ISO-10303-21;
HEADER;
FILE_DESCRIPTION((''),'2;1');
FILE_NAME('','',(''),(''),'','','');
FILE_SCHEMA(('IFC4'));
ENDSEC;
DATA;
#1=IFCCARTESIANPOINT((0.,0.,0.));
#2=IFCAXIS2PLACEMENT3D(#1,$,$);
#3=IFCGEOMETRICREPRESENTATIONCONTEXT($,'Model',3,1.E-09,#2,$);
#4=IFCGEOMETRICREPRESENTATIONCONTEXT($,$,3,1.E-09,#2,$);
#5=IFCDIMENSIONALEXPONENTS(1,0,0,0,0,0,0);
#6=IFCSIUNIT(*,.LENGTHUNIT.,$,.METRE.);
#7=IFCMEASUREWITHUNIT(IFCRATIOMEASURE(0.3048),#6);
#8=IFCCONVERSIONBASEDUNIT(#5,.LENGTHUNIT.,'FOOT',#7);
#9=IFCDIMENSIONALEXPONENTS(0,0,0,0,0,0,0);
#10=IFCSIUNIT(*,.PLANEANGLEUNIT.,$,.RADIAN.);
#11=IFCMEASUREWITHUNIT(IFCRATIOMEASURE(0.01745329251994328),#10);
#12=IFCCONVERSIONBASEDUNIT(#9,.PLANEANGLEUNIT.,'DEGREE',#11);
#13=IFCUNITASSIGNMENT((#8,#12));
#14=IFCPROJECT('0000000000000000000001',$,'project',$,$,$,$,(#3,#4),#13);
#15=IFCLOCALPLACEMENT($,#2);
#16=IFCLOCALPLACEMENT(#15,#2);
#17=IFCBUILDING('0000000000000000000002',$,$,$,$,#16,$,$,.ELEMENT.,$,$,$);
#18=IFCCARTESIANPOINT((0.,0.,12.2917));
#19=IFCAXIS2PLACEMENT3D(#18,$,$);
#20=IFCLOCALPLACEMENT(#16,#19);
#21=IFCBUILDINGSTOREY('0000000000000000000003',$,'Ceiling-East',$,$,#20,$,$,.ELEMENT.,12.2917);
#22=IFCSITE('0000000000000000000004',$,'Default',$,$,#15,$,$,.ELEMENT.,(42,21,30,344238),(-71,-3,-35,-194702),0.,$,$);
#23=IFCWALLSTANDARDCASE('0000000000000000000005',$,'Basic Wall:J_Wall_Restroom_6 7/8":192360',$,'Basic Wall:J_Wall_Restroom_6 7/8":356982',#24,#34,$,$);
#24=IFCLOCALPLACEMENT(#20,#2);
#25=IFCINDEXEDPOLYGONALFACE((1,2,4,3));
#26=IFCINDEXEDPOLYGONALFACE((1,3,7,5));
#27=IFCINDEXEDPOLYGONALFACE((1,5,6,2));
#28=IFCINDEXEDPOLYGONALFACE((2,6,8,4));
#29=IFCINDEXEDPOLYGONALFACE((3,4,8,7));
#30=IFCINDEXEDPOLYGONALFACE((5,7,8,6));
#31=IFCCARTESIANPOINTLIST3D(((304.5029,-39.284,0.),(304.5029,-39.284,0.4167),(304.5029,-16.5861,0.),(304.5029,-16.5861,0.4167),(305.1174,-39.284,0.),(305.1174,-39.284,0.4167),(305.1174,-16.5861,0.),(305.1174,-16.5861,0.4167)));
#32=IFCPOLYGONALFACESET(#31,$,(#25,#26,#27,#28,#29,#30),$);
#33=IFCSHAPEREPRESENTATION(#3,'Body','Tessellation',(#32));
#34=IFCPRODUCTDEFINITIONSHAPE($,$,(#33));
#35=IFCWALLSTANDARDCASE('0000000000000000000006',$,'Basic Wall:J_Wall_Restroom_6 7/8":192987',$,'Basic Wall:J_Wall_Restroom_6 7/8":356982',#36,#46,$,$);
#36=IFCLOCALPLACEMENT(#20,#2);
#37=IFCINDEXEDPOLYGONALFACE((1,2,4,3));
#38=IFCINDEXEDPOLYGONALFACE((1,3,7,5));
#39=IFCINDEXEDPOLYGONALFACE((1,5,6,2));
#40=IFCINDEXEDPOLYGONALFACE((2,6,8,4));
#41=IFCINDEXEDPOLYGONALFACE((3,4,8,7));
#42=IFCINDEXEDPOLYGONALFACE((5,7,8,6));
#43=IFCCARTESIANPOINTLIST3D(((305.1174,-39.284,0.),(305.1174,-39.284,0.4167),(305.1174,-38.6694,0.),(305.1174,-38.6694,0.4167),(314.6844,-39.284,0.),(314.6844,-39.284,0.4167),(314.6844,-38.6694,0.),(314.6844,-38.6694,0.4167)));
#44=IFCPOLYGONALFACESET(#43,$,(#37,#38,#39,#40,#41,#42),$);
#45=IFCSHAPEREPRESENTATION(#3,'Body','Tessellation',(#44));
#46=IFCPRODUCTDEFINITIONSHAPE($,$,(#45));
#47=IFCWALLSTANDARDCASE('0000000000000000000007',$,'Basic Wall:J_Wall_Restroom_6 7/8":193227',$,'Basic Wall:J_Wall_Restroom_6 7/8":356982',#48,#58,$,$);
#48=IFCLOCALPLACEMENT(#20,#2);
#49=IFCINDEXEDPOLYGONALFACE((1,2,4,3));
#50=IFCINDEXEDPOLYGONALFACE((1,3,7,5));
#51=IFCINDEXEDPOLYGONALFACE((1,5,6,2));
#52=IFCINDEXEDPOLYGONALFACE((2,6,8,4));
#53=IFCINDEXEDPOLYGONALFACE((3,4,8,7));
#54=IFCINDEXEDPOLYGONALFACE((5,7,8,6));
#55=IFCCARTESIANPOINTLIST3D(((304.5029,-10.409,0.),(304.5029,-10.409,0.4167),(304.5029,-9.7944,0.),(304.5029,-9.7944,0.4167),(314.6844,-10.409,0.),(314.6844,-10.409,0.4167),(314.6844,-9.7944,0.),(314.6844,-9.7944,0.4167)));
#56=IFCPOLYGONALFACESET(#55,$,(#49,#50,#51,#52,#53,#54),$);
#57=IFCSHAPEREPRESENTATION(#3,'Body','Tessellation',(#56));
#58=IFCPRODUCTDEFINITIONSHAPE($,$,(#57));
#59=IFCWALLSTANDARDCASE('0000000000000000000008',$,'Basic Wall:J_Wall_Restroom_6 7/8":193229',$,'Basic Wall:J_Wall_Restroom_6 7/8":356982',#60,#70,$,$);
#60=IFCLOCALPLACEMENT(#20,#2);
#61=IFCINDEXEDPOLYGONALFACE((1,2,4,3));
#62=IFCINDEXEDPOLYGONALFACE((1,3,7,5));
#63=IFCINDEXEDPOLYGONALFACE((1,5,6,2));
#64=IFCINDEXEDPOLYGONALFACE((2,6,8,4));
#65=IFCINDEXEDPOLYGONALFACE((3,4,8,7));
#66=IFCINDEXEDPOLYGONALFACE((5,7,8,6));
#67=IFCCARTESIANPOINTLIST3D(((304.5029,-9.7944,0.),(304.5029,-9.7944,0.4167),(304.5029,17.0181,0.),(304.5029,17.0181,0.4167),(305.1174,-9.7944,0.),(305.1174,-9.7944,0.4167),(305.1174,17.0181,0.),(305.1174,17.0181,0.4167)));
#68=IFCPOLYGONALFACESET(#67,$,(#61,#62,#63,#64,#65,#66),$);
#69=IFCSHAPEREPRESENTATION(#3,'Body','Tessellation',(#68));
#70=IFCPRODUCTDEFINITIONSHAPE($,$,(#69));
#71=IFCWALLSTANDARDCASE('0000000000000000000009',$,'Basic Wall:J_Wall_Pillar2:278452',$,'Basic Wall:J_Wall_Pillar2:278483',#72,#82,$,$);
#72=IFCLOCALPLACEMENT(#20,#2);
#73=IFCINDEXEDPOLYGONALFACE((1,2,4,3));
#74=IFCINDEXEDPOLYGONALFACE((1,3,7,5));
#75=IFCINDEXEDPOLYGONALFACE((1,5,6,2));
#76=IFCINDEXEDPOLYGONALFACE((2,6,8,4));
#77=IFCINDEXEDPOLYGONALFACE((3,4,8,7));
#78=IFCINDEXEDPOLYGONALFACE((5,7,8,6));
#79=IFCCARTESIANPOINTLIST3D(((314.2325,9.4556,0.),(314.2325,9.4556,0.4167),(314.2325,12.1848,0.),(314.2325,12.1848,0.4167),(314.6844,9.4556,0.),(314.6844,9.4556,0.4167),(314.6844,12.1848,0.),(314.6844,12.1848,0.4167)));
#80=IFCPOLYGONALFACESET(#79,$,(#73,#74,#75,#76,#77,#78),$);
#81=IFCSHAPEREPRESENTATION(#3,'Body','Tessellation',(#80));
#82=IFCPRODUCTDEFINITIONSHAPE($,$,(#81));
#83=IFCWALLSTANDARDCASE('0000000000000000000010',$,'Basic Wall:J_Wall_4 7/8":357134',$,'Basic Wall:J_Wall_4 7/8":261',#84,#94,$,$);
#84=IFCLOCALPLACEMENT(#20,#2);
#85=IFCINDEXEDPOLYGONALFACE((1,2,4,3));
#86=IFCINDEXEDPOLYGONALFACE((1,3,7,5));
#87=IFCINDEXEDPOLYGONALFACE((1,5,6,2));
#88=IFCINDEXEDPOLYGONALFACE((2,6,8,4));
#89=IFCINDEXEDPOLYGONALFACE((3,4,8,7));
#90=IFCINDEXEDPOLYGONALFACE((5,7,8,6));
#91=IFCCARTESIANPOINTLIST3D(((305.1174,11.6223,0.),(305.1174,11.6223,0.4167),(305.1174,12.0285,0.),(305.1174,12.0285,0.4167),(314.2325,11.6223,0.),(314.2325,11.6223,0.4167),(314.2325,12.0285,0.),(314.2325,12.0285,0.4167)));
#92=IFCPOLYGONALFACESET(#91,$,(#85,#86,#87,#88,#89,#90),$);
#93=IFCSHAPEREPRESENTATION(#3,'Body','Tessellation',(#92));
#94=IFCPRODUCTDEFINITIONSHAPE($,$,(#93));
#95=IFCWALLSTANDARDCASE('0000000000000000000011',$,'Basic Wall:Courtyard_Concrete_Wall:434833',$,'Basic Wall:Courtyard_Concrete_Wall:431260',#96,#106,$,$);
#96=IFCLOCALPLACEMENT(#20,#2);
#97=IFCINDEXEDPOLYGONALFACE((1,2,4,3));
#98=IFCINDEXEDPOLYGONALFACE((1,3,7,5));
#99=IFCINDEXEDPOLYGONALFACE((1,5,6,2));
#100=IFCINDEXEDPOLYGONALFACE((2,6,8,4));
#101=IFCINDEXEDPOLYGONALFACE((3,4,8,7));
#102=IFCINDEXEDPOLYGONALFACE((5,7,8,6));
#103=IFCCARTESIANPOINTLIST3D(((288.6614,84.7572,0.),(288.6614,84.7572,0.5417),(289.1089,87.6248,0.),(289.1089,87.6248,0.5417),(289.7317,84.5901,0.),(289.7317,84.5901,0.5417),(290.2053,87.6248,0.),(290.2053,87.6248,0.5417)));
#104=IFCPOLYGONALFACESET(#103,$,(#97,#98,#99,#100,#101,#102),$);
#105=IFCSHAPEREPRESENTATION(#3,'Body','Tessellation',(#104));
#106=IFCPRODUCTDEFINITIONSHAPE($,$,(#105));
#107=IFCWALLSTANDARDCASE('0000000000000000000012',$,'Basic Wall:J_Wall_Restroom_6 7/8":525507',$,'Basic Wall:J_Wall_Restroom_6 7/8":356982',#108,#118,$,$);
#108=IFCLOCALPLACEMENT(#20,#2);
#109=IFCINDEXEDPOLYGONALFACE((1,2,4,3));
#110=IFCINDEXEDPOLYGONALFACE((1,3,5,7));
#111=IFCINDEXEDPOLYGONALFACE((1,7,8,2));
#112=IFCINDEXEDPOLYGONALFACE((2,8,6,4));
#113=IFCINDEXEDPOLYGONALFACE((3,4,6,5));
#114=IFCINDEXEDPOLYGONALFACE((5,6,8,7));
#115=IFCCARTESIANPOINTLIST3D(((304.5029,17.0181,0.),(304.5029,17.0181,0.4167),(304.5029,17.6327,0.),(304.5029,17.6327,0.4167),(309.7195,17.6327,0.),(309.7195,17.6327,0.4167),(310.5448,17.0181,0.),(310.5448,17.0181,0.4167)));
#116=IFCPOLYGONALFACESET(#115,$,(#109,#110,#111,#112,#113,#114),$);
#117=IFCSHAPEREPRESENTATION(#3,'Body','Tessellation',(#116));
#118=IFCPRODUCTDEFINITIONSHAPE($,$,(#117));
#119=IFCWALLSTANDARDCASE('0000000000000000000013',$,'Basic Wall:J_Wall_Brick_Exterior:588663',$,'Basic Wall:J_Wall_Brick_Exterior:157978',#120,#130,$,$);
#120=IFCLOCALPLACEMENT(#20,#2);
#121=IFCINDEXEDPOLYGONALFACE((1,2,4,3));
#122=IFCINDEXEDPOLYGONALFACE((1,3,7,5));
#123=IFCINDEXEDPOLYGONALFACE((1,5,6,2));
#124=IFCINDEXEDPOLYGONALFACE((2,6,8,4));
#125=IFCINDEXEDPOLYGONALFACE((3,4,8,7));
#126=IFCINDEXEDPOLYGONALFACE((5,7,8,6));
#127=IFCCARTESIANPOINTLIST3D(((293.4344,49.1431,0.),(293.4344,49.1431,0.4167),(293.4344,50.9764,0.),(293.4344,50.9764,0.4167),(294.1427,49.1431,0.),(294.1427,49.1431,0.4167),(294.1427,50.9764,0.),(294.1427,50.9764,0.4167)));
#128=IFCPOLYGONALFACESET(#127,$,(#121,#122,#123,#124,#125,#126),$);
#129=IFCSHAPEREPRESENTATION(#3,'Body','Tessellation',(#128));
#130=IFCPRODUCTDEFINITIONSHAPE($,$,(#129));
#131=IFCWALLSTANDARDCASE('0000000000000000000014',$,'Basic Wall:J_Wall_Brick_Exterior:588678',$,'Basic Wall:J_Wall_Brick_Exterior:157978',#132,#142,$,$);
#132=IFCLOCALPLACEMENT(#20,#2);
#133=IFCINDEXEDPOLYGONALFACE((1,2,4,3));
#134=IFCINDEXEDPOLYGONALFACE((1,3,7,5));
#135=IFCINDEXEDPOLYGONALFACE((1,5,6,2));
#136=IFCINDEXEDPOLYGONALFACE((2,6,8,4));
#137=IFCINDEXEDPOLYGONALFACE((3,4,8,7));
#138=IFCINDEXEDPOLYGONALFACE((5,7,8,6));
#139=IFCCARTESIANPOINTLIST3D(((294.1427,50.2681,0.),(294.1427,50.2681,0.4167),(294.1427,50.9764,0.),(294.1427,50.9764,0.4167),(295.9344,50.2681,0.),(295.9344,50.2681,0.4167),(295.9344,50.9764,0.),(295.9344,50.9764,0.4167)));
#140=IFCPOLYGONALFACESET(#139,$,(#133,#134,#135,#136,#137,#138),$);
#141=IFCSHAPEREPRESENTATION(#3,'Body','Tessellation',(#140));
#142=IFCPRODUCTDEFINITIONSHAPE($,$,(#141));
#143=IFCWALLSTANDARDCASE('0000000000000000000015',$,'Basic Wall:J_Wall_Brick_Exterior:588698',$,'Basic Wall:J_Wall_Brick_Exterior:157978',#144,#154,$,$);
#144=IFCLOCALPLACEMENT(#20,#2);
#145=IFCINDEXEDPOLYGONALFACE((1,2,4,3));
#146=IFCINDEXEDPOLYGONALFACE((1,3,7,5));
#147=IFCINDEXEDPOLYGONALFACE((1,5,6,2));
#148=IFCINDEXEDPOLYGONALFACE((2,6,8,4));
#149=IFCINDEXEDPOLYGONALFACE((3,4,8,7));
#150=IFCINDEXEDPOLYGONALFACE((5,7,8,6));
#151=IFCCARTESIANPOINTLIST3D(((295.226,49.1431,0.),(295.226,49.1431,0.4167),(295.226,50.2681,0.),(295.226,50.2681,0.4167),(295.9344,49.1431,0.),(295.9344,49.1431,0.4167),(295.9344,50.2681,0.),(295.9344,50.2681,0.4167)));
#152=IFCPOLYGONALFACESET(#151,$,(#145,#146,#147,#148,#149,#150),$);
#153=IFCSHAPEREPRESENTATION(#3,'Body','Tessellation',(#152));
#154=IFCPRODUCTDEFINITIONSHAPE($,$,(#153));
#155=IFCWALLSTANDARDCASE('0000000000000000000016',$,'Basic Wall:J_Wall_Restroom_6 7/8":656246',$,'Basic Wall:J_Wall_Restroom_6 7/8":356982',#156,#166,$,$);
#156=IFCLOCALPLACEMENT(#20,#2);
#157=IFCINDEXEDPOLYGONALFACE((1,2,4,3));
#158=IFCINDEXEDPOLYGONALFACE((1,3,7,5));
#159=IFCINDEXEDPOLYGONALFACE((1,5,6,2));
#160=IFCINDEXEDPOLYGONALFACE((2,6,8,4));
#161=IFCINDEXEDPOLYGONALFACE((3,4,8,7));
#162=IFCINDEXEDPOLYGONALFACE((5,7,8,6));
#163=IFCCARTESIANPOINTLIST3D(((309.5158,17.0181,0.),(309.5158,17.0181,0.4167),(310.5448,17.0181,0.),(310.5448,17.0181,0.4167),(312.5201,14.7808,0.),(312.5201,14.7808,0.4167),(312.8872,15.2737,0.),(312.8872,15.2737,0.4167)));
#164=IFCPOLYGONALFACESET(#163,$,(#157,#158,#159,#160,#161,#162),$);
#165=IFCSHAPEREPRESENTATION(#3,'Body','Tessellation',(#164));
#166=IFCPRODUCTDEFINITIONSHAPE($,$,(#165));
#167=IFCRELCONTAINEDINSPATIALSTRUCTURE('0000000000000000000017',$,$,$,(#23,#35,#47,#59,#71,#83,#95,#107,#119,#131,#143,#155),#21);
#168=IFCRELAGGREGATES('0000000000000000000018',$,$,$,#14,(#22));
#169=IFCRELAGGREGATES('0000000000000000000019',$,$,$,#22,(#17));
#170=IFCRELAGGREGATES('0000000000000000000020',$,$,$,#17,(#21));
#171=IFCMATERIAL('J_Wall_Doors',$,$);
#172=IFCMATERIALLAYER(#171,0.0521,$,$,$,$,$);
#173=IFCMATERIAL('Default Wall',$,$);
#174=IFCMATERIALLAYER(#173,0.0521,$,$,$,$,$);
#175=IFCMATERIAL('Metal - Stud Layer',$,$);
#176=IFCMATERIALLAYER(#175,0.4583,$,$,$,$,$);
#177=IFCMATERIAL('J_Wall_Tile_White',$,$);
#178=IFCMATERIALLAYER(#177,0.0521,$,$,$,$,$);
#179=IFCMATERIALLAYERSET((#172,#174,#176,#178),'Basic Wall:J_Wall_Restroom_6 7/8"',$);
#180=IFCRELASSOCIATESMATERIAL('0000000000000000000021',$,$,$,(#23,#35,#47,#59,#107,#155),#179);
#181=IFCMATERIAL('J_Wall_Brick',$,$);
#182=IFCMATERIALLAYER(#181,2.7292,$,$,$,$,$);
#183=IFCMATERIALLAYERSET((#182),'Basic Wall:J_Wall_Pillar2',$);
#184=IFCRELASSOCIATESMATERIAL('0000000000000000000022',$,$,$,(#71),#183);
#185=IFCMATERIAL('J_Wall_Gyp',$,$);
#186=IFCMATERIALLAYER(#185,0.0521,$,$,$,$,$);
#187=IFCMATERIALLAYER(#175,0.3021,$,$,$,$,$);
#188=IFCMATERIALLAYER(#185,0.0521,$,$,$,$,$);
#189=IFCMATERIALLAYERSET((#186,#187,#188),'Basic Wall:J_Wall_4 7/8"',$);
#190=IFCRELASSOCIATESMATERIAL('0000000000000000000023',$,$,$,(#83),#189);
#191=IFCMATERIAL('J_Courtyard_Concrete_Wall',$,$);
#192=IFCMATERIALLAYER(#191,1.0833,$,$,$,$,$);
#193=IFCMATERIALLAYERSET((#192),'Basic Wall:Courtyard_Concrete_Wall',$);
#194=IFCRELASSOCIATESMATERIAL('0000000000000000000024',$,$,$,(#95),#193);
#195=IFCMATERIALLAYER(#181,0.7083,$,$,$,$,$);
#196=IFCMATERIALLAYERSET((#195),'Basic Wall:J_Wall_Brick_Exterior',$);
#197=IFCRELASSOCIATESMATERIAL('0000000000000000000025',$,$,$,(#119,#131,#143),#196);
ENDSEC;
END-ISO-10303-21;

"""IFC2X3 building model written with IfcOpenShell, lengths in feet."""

from ifc_helpers import new_model, entity, si_unit, converted_unit, frame, frame_2d, origin, place, context, project, spatial, polyline, rectangle, outline, extrude, clip, halfspace, material, layer, layer_set, layer_usage, element, save


model = new_model("IFC2X3")

# Units and contexts
model_context = context("Model", 3, precision=1e-09, world=origin())
context_of_model = context(None, 3, precision=1e-09, world=origin())
ifc_project = project(units=[converted_unit("LENGTHUNIT", "FOOT", entity("IfcRatioMeasure", 0.3048), si_unit("LENGTHUNIT", "METRE"), dimensions=[1, 0, 0, 0, 0, 0, 0]), converted_unit("PLANEANGLEUNIT", "DEGREE", entity("IfcRatioMeasure", 0.01745329251994328), si_unit("PLANEANGLEUNIT", "RADIAN"), dimensions=[0, 0, 0, 0, 0, 0, 0])], contexts=[model_context, context_of_model])

# Site, building, storey
site_placement = place(None, origin())
site = spatial("IfcSite", under=ifc_project, at=site_placement, Name="Default", CompositionType="ELEMENT", RefLatitude=(42, 21, 30, 344238), RefLongitude=(-71, -3, -35, -194702), RefElevation=0.0)
building_placement = place(site_placement, origin())
building = spatial("IfcBuilding", under=site, at=building_placement, CompositionType="ELEMENT")
storey_placement = place(building_placement, frame((0.0, 0.0, 12.2917)))
storey = spatial("IfcBuildingStorey", under=building, at=storey_placement, Name="Ceiling-East", CompositionType="ELEMENT", Elevation=12.2917)

# Shared definitions
ifc_material_1 = material(Name="J_Wall_Brick")
ifc_layer_1 = layer(ifc_material_1, 0.7083)
ifc_layer_set_1 = layer_set([ifc_layer_1], Name="Basic Wall:J_Wall_Brick_Exterior")

# Walls
ifc_material_2 = material(Name="J_Wall_Doors")
ifc_layer_2 = layer(ifc_material_2, 0.0521)
ifc_material_3 = material(Name="Default Wall")
ifc_layer_3 = layer(ifc_material_3, 0.0521)
ifc_material_4 = material(Name="Metal - Stud Layer")
ifc_layer_4 = layer(ifc_material_4, 0.4583)
ifc_material_5 = material(Name="J_Wall_Tile_White")
ifc_layer_5 = layer(ifc_material_5, 0.0521)
ifc_layer_set_2 = layer_set([ifc_layer_2, ifc_layer_3, ifc_layer_4, ifc_layer_5], Name="Basic Wall:J_Wall_Restroom_6 7/8\"")
ifc_layer_usage_1 = layer_usage(ifc_layer_set_2, "AXIS2", "POSITIVE", -0.3073)
wall_1_placement = place(storey_placement, frame((304.8101, -16.5861, 0.0), z_axis=(0.0, 0.0, 1.0), x_axis=(0.0, -1.0, 0.0)))
element("IfcWallStandardCase", 1, at=wall_1_placement, inside=storey, material=ifc_layer_usage_1, Name="Basic Wall:J_Wall_Restroom_6 7/8\":192360", ObjectType="Basic Wall:J_Wall_Restroom_6 7/8\":356982", context=model_context, shape_type="Clipping", body=[
    clip(extrude(rectangle(XDim=22.6979, YDim=0.6146, at=frame_2d((11.349, 0.0), x_axis=(-1.0, 0.0))), origin(), (0.0, 0.0, 1.0), 0.4167), halfspace(frame((0.0, 0.0, -12.125)), True)),
])
ifc_layer_usage_2 = layer_usage(ifc_layer_set_2, "AXIS2", "NEGATIVE", 0.3073)
wall_2_placement = place(storey_placement, frame((314.6844, -38.9767, 0.0), z_axis=(0.0, 0.0, 1.0), x_axis=(-1.0, 0.0, 0.0)))
element("IfcWallStandardCase", 2, at=wall_2_placement, inside=storey, material=ifc_layer_usage_2, Name="Basic Wall:J_Wall_Restroom_6 7/8\":192987", ObjectType="Basic Wall:J_Wall_Restroom_6 7/8\":356982", context=model_context, shape_type="Clipping", body=[
    clip(extrude(rectangle(XDim=9.5669, YDim=0.6146, at=frame_2d((4.7835, 0.0), x_axis=(-1.0, 0.0))), origin(), (0.0, 0.0, 1.0), 0.4167), halfspace(frame((0.0, 0.0, -12.125)), True)),
])
ifc_layer_usage_3 = layer_usage(ifc_layer_set_2, "AXIS2", "NEGATIVE", 0.3073)
wall_3_placement = place(storey_placement, frame((314.6844, -10.1017, 0.0), z_axis=(0.0, 0.0, 1.0), x_axis=(-1.0, 0.0, 0.0)))
element("IfcWallStandardCase", 3, at=wall_3_placement, inside=storey, material=ifc_layer_usage_3, Name="Basic Wall:J_Wall_Restroom_6 7/8\":193227", ObjectType="Basic Wall:J_Wall_Restroom_6 7/8\":356982", context=model_context, shape_type="Clipping", body=[
    clip(extrude(rectangle(XDim=10.1815, YDim=0.6146, at=frame_2d((5.0907, 0.0), x_axis=(-1.0, 0.0))), origin(), (0.0, 0.0, 1.0), 0.4167), halfspace(frame((0.0, 0.0, -12.125)), True)),
])
ifc_layer_usage_4 = layer_usage(ifc_layer_set_2, "AXIS2", "NEGATIVE", 0.3073)
wall_4_placement = place(storey_placement, frame((304.8101, -9.7944, 0.0), z_axis=(0.0, 0.0, 1.0), x_axis=(0.0, 1.0, 0.0)))
element("IfcWallStandardCase", 4, at=wall_4_placement, inside=storey, material=ifc_layer_usage_4, Name="Basic Wall:J_Wall_Restroom_6 7/8\":193229", ObjectType="Basic Wall:J_Wall_Restroom_6 7/8\":356982", context=model_context, shape_type="Clipping", body=[
    clip(extrude(rectangle(XDim=26.8125, YDim=0.6146, at=frame_2d((13.4063, 0.0), x_axis=(-1.0, 0.0))), origin(), (0.0, 0.0, 1.0), 0.4167), halfspace(frame((0.0, 0.0, -12.125)), True)),
])
ifc_layer_6 = layer(ifc_material_1, 2.7292)
ifc_layer_set_3 = layer_set([ifc_layer_6], Name="Basic Wall:J_Wall_Pillar2")
ifc_layer_usage_5 = layer_usage(ifc_layer_set_3, "AXIS2", "NEGATIVE", 1.3646)
wall_5_placement = place(storey_placement, frame((314.6844, 10.8202, 0.0), z_axis=(0.0, 0.0, 1.0), x_axis=(-1.0, 0.0, 0.0)))
element("IfcWallStandardCase", 5, at=wall_5_placement, inside=storey, material=ifc_layer_usage_5, Name="Basic Wall:J_Wall_Pillar2:278452", ObjectType="Basic Wall:J_Wall_Pillar2:278483", context=model_context, shape_type="Clipping", body=[
    clip(extrude(rectangle(XDim=0.4519, YDim=2.7292, at=frame_2d((0.2259, 0.0), x_axis=(-1.0, 0.0))), origin(), (0.0, 0.0, 1.0), 0.4167), halfspace(frame((0.0, 0.0, -12.125)), True)),
])
ifc_material_6 = material(Name="J_Wall_Gyp")
ifc_layer_7 = layer(ifc_material_6, 0.0521)
ifc_layer_8 = layer(ifc_material_4, 0.3021)
ifc_layer_9 = layer(ifc_material_6, 0.0521)
ifc_layer_set_4 = layer_set([ifc_layer_7, ifc_layer_8, ifc_layer_9], Name="Basic Wall:J_Wall_4 7/8\"")
ifc_layer_usage_6 = layer_usage(ifc_layer_set_4, "AXIS2", "NEGATIVE", 0.2031)
wall_6_placement = place(storey_placement, frame((305.1174, 11.8254, 0.0)))
element("IfcWallStandardCase", 6, at=wall_6_placement, inside=storey, material=ifc_layer_usage_6, Name="Basic Wall:J_Wall_4 7/8\":357134", ObjectType="Basic Wall:J_Wall_4 7/8\":261", context=model_context, shape_type="Clipping", body=[
    clip(extrude(rectangle(XDim=9.1151, YDim=0.4062, at=frame_2d((4.5575, 0.0), x_axis=(-1.0, 0.0))), origin(), (0.0, 0.0, 1.0), 0.4167), halfspace(frame((0.0, 0.0, -12.125)), True)),
])
ifc_material_7 = material(Name="J_Courtyard_Concrete_Wall")
ifc_layer_10 = layer(ifc_material_7, 1.0833)
ifc_layer_set_5 = layer_set([ifc_layer_10], Name="Basic Wall:Courtyard_Concrete_Wall")
ifc_layer_usage_7 = layer_usage(ifc_layer_set_5, "AXIS2", "NEGATIVE", 0.5417)
wall_7_placement = place(storey_placement, frame((289.6701, 87.7083, 0.0), z_axis=(0.0, 0.0, 1.0), x_axis=(-0.154194, -0.988041, 0.0)))
element("IfcWallStandardCase", 7, at=wall_7_placement, inside=storey, material=ifc_layer_usage_7, Name="Basic Wall:Courtyard_Concrete_Wall:434833", ObjectType="Basic Wall:Courtyard_Concrete_Wall:431260", context=model_context, shape_type="Clipping", body=[
    clip(extrude(outline(polyline([(3.0714, -0.5417), (3.0714, 0.5417), (0.0, 0.5417), (0.1691, -0.5417), (3.0714, -0.5417)])), origin(), (0.0, 0.0, 1.0), 0.5417), halfspace(frame((0.0, 0.0, -12.125)), True)),
])

# Walls
ifc_layer_usage_8 = layer_usage(ifc_layer_set_2, "AXIS2", "NEGATIVE", 0.3073)
wall_8_placement = place(storey_placement, frame((304.5029, 17.3254, 0.0)))
element("IfcWallStandardCase", 8, at=wall_8_placement, inside=storey, material=ifc_layer_usage_8, Name="Basic Wall:J_Wall_Restroom_6 7/8\":525507", ObjectType="Basic Wall:J_Wall_Restroom_6 7/8\":356982", context=model_context, shape_type="Clipping", body=[
    clip(extrude(outline(polyline([(6.0419, -0.3073), (5.2167, 0.3073), (0.0, 0.3073), (0.0, -0.3073), (0.6146, -0.3073), (5.013, -0.3073), (6.0419, -0.3073)])), origin(), (0.0, 0.0, 1.0), 0.4167), halfspace(frame((0.0, 0.0, -12.125)), True)),
])
ifc_layer_usage_9 = layer_usage(ifc_layer_set_1, "AXIS2", "POSITIVE", -0.3542)
wall_9_placement = place(storey_placement, frame((293.7885, 49.1431, 0.0), z_axis=(0.0, 0.0, 1.0), x_axis=(0.0, 1.0, 0.0)))
element("IfcWallStandardCase", 9, at=wall_9_placement, inside=storey, material=ifc_layer_usage_9, Name="Basic Wall:J_Wall_Brick_Exterior:588663", ObjectType="Basic Wall:J_Wall_Brick_Exterior:157978", context=model_context, shape_type="Clipping", body=[
    clip(extrude(rectangle(XDim=1.8333, YDim=0.7083, at=frame_2d((0.9167, 0.0), x_axis=(-1.0, 0.0))), origin(), (0.0, 0.0, 1.0), 0.4167), halfspace(frame((0.0, 0.0, -12.125)), True)),
])
ifc_layer_usage_10 = layer_usage(ifc_layer_set_1, "AXIS2", "POSITIVE", -0.3542)
wall_10_placement = place(storey_placement, frame((294.1427, 50.6223, 0.0)))
element("IfcWallStandardCase", 10, at=wall_10_placement, inside=storey, material=ifc_layer_usage_10, Name="Basic Wall:J_Wall_Brick_Exterior:588678", ObjectType="Basic Wall:J_Wall_Brick_Exterior:157978", context=model_context, shape_type="Clipping", body=[
    clip(extrude(rectangle(XDim=1.7917, YDim=0.7083, at=frame_2d((0.8958, 0.0), x_axis=(-1.0, 0.0))), origin(), (0.0, 0.0, 1.0), 0.4167), halfspace(frame((0.0, 0.0, -12.125)), True)),
])
ifc_layer_usage_11 = layer_usage(ifc_layer_set_1, "AXIS2", "POSITIVE", -0.3542)
wall_11_placement = place(storey_placement, frame((295.5802, 50.2681, 0.0), z_axis=(0.0, 0.0, 1.0), x_axis=(0.0, -1.0, 0.0)))
element("IfcWallStandardCase", 11, at=wall_11_placement, inside=storey, material=ifc_layer_usage_11, Name="Basic Wall:J_Wall_Brick_Exterior:588698", ObjectType="Basic Wall:J_Wall_Brick_Exterior:157978", context=model_context, shape_type="Clipping", body=[
    clip(extrude(rectangle(XDim=1.125, YDim=0.7083, at=frame_2d((0.5625, 0.0), x_axis=(-1.0, 0.0))), origin(), (0.0, 0.0, 1.0), 0.4167), halfspace(frame((0.0, 0.0, -12.125)), True)),
])
ifc_layer_usage_12 = layer_usage(ifc_layer_set_2, "AXIS2", "POSITIVE", -0.3073)
wall_12_placement = place(storey_placement, frame((312.7037, 15.0272, 0.0), z_axis=(0.0, 0.0, 1.0), x_axis=(-0.802039, 0.597272, 0.0)))
element("IfcWallStandardCase", 12, at=wall_12_placement, inside=storey, material=ifc_layer_usage_12, Name="Basic Wall:J_Wall_Restroom_6 7/8\":656246", ObjectType="Basic Wall:J_Wall_Restroom_6 7/8\":356982", context=model_context, shape_type="Clipping", body=[
    clip(extrude(outline(polyline([(2.9206, -0.3073), (3.7459, 0.3073), (0.0, 0.3073), (0.0, -0.3073), (2.9206, -0.3073)])), origin(), (0.0, 0.0, 1.0), 0.4167), halfspace(frame((0.0, 0.0, -12.125)), True)),
])

save(model, "model.ifc")
